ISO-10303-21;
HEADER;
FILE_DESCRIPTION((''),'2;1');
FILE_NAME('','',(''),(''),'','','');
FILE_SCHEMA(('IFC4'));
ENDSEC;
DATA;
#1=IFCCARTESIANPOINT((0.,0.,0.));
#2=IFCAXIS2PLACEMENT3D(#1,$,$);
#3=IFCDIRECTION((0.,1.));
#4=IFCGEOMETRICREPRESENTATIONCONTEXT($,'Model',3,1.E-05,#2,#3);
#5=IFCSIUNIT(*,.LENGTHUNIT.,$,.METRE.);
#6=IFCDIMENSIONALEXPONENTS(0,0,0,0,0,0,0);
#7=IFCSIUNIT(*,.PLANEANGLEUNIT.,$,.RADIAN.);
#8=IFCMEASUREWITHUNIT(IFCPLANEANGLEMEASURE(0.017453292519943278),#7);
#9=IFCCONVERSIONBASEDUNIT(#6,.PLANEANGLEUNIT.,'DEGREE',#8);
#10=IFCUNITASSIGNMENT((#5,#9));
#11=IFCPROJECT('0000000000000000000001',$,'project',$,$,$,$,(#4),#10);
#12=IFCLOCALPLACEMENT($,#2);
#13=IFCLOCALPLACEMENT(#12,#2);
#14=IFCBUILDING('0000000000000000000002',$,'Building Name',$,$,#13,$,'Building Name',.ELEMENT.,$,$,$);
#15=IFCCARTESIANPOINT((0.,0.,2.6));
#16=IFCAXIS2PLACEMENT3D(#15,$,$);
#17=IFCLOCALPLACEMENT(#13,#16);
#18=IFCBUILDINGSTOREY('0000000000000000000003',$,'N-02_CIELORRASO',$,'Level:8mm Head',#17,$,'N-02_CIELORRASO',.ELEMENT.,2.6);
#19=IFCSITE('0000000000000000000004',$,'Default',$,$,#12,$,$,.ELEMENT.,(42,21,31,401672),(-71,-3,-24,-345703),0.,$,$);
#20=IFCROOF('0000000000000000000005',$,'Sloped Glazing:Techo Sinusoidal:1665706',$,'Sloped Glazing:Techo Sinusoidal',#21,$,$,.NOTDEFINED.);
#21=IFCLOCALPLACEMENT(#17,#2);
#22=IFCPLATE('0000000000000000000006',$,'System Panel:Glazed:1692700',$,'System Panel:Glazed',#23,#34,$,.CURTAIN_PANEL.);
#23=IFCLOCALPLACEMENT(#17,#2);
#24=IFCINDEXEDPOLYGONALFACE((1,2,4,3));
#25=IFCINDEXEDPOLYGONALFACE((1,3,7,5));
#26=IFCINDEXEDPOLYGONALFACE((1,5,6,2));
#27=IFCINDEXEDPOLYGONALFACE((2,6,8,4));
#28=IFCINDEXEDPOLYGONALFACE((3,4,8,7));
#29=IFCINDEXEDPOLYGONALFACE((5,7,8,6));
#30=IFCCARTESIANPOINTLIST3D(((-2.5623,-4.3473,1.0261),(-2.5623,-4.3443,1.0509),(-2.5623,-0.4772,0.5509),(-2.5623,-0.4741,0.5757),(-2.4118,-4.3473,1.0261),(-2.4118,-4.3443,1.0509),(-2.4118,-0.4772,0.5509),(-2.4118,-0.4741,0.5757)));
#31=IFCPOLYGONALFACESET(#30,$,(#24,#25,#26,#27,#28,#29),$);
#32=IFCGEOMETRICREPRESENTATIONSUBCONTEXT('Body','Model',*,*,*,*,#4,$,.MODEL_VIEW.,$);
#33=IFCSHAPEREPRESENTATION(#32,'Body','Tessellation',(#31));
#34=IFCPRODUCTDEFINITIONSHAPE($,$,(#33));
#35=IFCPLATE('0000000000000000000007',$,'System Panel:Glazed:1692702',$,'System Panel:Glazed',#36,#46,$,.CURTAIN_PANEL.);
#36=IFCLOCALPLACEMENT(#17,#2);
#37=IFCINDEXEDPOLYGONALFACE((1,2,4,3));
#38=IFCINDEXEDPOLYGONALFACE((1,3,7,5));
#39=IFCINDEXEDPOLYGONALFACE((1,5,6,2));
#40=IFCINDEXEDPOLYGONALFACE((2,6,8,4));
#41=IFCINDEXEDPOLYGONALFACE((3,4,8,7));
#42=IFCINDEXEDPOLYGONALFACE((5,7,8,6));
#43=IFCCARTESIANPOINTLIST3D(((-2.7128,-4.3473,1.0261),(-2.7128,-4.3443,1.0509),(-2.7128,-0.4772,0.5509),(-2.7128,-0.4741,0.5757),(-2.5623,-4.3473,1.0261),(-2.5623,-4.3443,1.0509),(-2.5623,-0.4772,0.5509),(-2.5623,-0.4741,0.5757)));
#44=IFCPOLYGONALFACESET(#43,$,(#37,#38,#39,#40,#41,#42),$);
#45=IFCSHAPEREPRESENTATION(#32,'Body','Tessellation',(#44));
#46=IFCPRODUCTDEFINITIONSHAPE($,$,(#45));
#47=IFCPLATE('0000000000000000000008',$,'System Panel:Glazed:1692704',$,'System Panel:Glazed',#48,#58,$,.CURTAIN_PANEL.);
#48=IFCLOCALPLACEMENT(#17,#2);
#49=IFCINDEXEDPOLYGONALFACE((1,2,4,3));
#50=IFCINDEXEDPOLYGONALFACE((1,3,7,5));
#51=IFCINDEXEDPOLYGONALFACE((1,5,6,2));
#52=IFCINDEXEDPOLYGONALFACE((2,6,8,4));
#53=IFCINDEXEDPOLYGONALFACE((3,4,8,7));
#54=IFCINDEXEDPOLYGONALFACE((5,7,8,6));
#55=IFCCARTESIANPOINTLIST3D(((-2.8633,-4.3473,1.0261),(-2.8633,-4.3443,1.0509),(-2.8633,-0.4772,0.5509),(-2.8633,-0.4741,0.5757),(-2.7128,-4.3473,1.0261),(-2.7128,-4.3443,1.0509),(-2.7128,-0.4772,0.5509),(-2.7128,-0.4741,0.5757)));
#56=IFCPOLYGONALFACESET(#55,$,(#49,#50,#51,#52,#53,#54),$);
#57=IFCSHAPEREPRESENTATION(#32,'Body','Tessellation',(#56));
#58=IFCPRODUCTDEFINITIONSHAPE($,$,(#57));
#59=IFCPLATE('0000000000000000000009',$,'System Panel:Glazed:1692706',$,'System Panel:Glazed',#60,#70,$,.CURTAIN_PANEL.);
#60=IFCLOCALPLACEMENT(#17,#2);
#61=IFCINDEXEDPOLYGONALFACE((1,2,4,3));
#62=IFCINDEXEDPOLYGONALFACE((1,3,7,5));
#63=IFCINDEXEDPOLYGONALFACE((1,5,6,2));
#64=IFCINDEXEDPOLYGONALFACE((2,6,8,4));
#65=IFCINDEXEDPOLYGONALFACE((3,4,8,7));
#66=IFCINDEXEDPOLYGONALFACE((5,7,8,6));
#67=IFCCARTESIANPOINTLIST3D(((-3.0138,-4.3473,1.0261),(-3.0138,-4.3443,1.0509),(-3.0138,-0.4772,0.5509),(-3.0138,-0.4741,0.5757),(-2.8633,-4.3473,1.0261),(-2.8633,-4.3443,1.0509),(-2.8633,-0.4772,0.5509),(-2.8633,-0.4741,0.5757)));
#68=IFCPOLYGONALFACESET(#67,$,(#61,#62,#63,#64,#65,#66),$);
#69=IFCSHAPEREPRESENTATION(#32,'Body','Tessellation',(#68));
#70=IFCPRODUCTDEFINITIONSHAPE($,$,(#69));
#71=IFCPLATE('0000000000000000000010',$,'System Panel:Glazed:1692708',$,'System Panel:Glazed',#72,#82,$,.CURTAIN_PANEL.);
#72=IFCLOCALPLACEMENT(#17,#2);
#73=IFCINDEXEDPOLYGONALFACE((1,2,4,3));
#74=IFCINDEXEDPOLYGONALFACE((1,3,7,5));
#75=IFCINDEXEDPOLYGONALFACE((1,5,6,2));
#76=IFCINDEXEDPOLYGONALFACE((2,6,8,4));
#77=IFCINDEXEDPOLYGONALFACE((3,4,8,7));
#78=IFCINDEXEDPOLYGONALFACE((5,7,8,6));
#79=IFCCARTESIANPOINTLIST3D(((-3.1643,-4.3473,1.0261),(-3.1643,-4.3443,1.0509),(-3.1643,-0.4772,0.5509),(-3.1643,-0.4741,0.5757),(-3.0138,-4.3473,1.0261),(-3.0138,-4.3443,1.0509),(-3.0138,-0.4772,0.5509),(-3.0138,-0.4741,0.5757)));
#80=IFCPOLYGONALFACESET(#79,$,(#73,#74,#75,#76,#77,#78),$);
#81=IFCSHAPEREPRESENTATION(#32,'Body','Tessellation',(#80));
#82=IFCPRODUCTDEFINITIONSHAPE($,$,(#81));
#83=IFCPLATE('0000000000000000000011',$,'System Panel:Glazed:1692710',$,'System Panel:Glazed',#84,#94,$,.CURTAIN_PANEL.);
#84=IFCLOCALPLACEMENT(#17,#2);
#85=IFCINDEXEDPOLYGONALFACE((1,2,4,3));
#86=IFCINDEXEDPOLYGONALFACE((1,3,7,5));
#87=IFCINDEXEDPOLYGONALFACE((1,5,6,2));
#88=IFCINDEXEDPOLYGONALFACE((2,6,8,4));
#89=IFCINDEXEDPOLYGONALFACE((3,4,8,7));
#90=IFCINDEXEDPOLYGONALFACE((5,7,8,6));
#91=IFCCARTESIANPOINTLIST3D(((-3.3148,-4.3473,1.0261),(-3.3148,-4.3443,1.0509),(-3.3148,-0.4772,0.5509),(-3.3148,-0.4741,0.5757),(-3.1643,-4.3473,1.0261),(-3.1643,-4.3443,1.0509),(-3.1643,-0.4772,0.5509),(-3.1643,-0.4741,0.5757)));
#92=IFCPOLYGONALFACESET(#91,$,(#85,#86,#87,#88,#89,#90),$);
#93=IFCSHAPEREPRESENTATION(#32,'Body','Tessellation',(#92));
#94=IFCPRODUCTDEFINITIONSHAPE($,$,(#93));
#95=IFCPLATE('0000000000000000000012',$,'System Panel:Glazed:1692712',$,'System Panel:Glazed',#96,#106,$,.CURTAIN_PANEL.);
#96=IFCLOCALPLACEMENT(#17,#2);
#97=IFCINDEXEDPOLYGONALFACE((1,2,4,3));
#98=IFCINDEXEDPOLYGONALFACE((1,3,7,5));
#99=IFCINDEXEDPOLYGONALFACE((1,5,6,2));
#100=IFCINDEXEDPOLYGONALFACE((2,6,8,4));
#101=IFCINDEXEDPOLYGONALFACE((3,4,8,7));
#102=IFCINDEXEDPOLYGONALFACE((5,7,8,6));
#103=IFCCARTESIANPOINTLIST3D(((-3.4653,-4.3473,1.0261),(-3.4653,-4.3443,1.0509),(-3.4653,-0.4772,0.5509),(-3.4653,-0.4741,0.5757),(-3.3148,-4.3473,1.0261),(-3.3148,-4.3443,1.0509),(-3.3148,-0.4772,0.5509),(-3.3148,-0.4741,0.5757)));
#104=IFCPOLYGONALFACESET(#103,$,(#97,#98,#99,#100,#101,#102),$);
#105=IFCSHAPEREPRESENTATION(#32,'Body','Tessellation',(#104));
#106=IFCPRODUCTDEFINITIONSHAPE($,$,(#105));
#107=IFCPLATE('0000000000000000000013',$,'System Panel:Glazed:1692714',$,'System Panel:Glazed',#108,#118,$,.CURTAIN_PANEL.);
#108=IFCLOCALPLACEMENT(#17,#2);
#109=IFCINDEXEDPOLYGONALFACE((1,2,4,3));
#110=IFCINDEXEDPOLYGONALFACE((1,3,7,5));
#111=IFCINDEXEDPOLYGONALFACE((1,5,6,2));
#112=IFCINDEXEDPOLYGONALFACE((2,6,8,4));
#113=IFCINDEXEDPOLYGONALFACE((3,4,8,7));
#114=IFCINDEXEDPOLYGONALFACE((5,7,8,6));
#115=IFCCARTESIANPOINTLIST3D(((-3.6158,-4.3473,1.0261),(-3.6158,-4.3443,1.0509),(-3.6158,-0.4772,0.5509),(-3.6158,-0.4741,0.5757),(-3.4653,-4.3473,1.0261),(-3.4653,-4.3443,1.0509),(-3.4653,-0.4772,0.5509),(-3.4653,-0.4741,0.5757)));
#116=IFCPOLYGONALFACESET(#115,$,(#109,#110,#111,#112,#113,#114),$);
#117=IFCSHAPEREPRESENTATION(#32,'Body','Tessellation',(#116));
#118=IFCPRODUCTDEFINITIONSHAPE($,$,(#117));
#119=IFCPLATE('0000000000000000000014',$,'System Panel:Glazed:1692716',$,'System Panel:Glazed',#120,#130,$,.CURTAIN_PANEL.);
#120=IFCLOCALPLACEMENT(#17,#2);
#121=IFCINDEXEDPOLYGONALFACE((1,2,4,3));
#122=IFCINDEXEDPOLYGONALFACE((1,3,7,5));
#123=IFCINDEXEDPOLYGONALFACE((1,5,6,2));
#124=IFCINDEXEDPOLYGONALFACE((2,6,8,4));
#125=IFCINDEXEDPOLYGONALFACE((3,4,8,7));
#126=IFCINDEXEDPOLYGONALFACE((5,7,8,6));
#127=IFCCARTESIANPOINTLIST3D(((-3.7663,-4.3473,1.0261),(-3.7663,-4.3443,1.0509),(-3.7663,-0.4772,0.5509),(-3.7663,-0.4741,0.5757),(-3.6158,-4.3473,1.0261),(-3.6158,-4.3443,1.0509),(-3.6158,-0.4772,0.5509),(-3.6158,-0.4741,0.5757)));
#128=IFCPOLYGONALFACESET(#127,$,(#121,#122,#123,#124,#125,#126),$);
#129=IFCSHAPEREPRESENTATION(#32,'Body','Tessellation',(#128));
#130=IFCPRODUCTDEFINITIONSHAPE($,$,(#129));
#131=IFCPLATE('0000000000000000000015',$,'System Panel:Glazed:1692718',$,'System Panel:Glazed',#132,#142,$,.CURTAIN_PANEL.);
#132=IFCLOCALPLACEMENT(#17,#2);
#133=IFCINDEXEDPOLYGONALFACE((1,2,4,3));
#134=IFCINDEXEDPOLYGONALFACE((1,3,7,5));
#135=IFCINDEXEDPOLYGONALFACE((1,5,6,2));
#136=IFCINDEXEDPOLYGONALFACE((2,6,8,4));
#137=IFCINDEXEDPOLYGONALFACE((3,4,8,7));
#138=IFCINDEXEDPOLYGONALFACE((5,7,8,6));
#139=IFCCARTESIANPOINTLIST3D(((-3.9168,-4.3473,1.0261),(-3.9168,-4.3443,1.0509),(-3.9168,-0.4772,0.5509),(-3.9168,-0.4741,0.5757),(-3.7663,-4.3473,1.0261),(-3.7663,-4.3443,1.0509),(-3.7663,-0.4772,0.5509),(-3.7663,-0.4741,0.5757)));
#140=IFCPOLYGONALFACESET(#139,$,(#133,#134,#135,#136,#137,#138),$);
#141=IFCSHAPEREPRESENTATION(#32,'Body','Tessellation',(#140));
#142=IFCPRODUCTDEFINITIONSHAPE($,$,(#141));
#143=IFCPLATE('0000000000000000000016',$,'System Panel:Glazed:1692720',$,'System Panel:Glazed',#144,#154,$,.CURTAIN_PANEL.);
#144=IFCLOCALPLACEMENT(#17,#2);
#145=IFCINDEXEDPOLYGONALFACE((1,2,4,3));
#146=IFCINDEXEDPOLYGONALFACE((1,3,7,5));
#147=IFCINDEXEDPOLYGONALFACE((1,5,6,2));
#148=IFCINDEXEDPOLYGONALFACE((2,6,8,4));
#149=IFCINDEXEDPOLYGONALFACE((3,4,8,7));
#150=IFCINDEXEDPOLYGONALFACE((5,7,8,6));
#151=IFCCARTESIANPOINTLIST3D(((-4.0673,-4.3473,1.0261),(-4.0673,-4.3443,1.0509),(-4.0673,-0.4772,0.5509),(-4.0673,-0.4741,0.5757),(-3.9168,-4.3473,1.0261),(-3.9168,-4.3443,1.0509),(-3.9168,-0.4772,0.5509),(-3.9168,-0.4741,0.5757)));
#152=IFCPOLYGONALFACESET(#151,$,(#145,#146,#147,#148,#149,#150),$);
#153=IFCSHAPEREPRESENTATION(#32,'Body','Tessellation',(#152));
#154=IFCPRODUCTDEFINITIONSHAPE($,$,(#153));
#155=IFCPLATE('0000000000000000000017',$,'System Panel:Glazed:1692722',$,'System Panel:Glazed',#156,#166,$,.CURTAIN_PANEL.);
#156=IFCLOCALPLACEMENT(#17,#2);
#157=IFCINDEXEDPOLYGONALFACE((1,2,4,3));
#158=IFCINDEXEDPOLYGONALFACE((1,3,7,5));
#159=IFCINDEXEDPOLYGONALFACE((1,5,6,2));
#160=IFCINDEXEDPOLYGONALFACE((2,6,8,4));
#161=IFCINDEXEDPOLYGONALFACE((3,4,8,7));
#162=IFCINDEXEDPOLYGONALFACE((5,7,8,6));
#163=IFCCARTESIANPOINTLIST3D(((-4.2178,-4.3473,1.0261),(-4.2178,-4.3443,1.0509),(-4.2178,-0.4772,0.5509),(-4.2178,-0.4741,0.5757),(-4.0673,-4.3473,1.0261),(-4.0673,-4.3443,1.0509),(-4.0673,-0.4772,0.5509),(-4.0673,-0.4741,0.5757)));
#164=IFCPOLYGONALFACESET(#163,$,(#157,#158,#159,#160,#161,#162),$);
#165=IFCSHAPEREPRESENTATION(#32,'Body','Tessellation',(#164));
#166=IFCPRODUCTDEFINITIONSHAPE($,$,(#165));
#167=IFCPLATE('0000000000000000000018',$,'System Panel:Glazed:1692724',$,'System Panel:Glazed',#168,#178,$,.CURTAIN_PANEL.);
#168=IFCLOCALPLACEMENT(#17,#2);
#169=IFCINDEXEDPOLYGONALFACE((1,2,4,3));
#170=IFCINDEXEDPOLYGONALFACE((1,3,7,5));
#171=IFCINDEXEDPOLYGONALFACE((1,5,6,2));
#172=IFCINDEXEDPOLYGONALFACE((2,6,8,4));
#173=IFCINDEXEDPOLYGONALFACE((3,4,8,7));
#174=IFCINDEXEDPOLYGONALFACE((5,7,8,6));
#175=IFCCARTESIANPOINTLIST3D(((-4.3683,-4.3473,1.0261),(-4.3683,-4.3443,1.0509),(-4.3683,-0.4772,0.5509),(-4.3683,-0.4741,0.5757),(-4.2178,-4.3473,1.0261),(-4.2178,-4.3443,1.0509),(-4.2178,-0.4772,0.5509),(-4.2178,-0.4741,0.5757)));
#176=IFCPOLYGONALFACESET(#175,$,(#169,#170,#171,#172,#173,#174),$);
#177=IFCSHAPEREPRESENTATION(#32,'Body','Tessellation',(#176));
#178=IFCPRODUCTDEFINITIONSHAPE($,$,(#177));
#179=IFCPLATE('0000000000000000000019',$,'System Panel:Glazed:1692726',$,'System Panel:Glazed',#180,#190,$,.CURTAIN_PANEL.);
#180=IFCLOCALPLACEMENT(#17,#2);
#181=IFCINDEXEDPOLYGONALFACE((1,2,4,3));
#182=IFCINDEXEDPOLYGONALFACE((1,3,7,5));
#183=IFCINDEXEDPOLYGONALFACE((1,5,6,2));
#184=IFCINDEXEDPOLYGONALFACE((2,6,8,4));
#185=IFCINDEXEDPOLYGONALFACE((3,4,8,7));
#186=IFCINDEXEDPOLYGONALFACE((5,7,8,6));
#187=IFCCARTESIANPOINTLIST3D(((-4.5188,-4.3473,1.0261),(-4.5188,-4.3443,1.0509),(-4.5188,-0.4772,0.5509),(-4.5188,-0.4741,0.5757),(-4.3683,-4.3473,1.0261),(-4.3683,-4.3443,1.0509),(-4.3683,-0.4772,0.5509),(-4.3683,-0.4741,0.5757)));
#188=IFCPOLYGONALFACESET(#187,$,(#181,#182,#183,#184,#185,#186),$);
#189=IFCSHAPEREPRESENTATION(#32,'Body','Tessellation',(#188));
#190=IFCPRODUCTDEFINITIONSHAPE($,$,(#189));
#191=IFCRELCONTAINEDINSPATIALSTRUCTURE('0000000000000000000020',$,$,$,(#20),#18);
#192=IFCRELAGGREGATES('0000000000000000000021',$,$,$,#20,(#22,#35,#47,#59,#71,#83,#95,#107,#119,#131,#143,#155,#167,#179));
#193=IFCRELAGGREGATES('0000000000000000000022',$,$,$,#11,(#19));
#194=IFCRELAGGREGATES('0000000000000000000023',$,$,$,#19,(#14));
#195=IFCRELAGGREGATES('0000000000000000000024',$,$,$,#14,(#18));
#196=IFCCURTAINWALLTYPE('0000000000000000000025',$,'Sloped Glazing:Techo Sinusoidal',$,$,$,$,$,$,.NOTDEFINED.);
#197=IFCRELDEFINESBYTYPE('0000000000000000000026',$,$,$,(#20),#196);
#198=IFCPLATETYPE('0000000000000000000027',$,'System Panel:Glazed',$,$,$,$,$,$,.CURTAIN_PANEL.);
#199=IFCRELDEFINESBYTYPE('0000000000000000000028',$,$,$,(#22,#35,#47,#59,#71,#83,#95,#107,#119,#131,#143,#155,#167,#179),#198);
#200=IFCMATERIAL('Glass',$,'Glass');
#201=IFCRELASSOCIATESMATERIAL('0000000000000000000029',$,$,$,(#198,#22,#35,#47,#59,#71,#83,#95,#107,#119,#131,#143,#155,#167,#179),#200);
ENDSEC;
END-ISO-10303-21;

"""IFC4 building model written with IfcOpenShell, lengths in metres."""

from ifc_helpers import new_model, entity, si_unit, converted_unit, direction, frame, origin, place, context, subcontext, project, spatial, indexed_curve, outline, extrude, source, transform, mapped, material, type_object, type_shapes, element, aggregate, save


model = new_model("IFC4")

# Units and contexts
model_context = context("Model", 3, precision=1e-05, world=origin(), true_north=direction((0.0, 1.0)))
body_context = subcontext(model_context, "Body", "Model", "MODEL_VIEW")
ifc_project = project(units=[si_unit("LENGTHUNIT", "METRE"), converted_unit("PLANEANGLEUNIT", "DEGREE", entity("IfcPlaneAngleMeasure", 0.017453292519943278), si_unit("PLANEANGLEUNIT", "RADIAN"), dimensions=[0, 0, 0, 0, 0, 0, 0])], contexts=[model_context])

# Site, building, storey
site_placement = place(None, origin())
site = spatial("IfcSite", under=ifc_project, at=site_placement, Name="Default", CompositionType="ELEMENT", RefLatitude=(42, 21, 31, 401672), RefLongitude=(-71, -3, -24, -345703), RefElevation=0.0)
building_placement = place(site_placement, origin())
building = spatial("IfcBuilding", under=site, at=building_placement, Name="Building Name", LongName="Building Name", CompositionType="ELEMENT")
storey_placement = place(building_placement, frame((0.0, 0.0, 2.6)))
storey = spatial("IfcBuildingStorey", under=building, at=storey_placement, Name="N-02_CIELORRASO", ObjectType="Level:8mm Head", LongName="N-02_CIELORRASO", CompositionType="ELEMENT", Elevation=2.6)

# Shared definitions
curtain_wall_type = type_object("IfcCurtainWallType", Name="Sloped Glazing:Techo Sinusoidal", PredefinedType="NOTDEFINED")

# Roof, plates
roof_1_placement = place(storey_placement, frame((0.0, 0.0, -2.6)))
roof_1 = element("IfcRoof", 1, at=roof_1_placement, inside=storey, type_object=curtain_wall_type, Name="Sloped Glazing:Techo Sinusoidal:1665706", ObjectType="Sloped Glazing:Techo Sinusoidal", PredefinedType="NOTDEFINED")
ifc_material_1 = material(Name="Glass", Category="Glass")
plate_type_1 = type_object("IfcPlateType", Name="System Panel:Glazed", PredefinedType="CURTAIN_PANEL", material=ifc_material_1)
shared_shape_1 = source(origin(), body_context, "Body", "SweptSolid", [
    extrude(outline(indexed_curve([(-0.0125, -0.0753), (0.0125, -0.0753), (0.0125, 0.0753), (-0.0125, 0.0753), (-0.0125, -0.0753)], self_intersect=False)), frame((0.0, 0.037, 0.0), z_axis=(0.0, 0.0, 1.0), x_axis=(0.0, 1.0, 0.0)), (0.0, 0.0, 1.0), 3.8992),
])
type_shapes(plate_type_1, [shared_shape_1])
plate_1_placement = place(roof_1_placement, frame((-2.487, -0.4711, 3.2), z_axis=(0.0, -0.992546, 0.121869), x_axis=(-1.0, 0.0, 0.0)))
plate_1 = element("IfcPlate", 2, at=plate_1_placement, type_object=plate_type_1, material=ifc_material_1, Name="System Panel:Glazed:1692700", ObjectType="System Panel:Glazed", PredefinedType="CURTAIN_PANEL", context=body_context, shape_type="MappedRepresentation", body=[
    mapped(shared_shape_1, transform((0.0, 0.0, 0.0), scale=1.0)),
])
plate_2_placement = place(roof_1_placement, frame((-2.6375, -0.4711, 3.2), z_axis=(0.0, -0.992546, 0.121869), x_axis=(-1.0, 0.0, 0.0)))
plate_2 = element("IfcPlate", 3, at=plate_2_placement, type_object=plate_type_1, material=ifc_material_1, Name="System Panel:Glazed:1692702", ObjectType="System Panel:Glazed", PredefinedType="CURTAIN_PANEL", context=body_context, shape_type="MappedRepresentation", body=[
    mapped(shared_shape_1, transform((0.0, 0.0, 0.0), scale=1.0)),
])
plate_3_placement = place(roof_1_placement, frame((-2.788, -0.4711, 3.2), z_axis=(0.0, -0.992546, 0.121869), x_axis=(-1.0, 0.0, 0.0)))
plate_3 = element("IfcPlate", 4, at=plate_3_placement, type_object=plate_type_1, material=ifc_material_1, Name="System Panel:Glazed:1692704", ObjectType="System Panel:Glazed", PredefinedType="CURTAIN_PANEL", context=body_context, shape_type="MappedRepresentation", body=[
    mapped(shared_shape_1, transform((0.0, 0.0, 0.0), scale=1.0)),
])
plate_4_placement = place(roof_1_placement, frame((-2.9385, -0.4711, 3.2), z_axis=(0.0, -0.992546, 0.121869), x_axis=(-1.0, 0.0, 0.0)))
plate_4 = element("IfcPlate", 5, at=plate_4_placement, type_object=plate_type_1, material=ifc_material_1, Name="System Panel:Glazed:1692706", ObjectType="System Panel:Glazed", PredefinedType="CURTAIN_PANEL", context=body_context, shape_type="MappedRepresentation", body=[
    mapped(shared_shape_1, transform((0.0, 0.0, 0.0), scale=1.0)),
])
plate_5_placement = place(roof_1_placement, frame((-3.089, -0.4711, 3.2), z_axis=(0.0, -0.992546, 0.121869), x_axis=(-1.0, 0.0, 0.0)))
plate_5 = element("IfcPlate", 6, at=plate_5_placement, type_object=plate_type_1, material=ifc_material_1, Name="System Panel:Glazed:1692708", ObjectType="System Panel:Glazed", PredefinedType="CURTAIN_PANEL", context=body_context, shape_type="MappedRepresentation", body=[
    mapped(shared_shape_1, transform((0.0, 0.0, 0.0), scale=1.0)),
])
plate_6_placement = place(roof_1_placement, frame((-3.2395, -0.4711, 3.2), z_axis=(0.0, -0.992546, 0.121869), x_axis=(-1.0, 0.0, 0.0)))
plate_6 = element("IfcPlate", 7, at=plate_6_placement, type_object=plate_type_1, material=ifc_material_1, Name="System Panel:Glazed:1692710", ObjectType="System Panel:Glazed", PredefinedType="CURTAIN_PANEL", context=body_context, shape_type="MappedRepresentation", body=[
    mapped(shared_shape_1, transform((0.0, 0.0, 0.0), scale=1.0)),
])
plate_7_placement = place(roof_1_placement, frame((-3.39, -0.4711, 3.2), z_axis=(0.0, -0.992546, 0.121869), x_axis=(-1.0, 0.0, 0.0)))
plate_7 = element("IfcPlate", 8, at=plate_7_placement, type_object=plate_type_1, material=ifc_material_1, Name="System Panel:Glazed:1692712", ObjectType="System Panel:Glazed", PredefinedType="CURTAIN_PANEL", context=body_context, shape_type="MappedRepresentation", body=[
    mapped(shared_shape_1, transform((0.0, 0.0, 0.0), scale=1.0)),
])
plate_8_placement = place(roof_1_placement, frame((-3.5405, -0.4711, 3.2), z_axis=(0.0, -0.992546, 0.121869), x_axis=(-1.0, 0.0, 0.0)))
plate_8 = element("IfcPlate", 9, at=plate_8_placement, type_object=plate_type_1, material=ifc_material_1, Name="System Panel:Glazed:1692714", ObjectType="System Panel:Glazed", PredefinedType="CURTAIN_PANEL", context=body_context, shape_type="MappedRepresentation", body=[
    mapped(shared_shape_1, transform((0.0, 0.0, 0.0), scale=1.0)),
])
plate_9_placement = place(roof_1_placement, frame((-3.691, -0.4711, 3.2), z_axis=(0.0, -0.992546, 0.121869), x_axis=(-1.0, 0.0, 0.0)))
plate_9 = element("IfcPlate", 10, at=plate_9_placement, type_object=plate_type_1, material=ifc_material_1, Name="System Panel:Glazed:1692716", ObjectType="System Panel:Glazed", PredefinedType="CURTAIN_PANEL", context=body_context, shape_type="MappedRepresentation", body=[
    mapped(shared_shape_1, transform((0.0, 0.0, 0.0), scale=1.0)),
])
plate_10_placement = place(roof_1_placement, frame((-3.8415, -0.4711, 3.2), z_axis=(0.0, -0.992546, 0.121869), x_axis=(-1.0, 0.0, 0.0)))
plate_10 = element("IfcPlate", 11, at=plate_10_placement, type_object=plate_type_1, material=ifc_material_1, Name="System Panel:Glazed:1692718", ObjectType="System Panel:Glazed", PredefinedType="CURTAIN_PANEL", context=body_context, shape_type="MappedRepresentation", body=[
    mapped(shared_shape_1, transform((0.0, 0.0, 0.0), scale=1.0)),
])
plate_11_placement = place(roof_1_placement, frame((-3.992, -0.4711, 3.2), z_axis=(0.0, -0.992546, 0.121869), x_axis=(-1.0, 0.0, 0.0)))
plate_11 = element("IfcPlate", 12, at=plate_11_placement, type_object=plate_type_1, material=ifc_material_1, Name="System Panel:Glazed:1692720", ObjectType="System Panel:Glazed", PredefinedType="CURTAIN_PANEL", context=body_context, shape_type="MappedRepresentation", body=[
    mapped(shared_shape_1, transform((0.0, 0.0, 0.0), scale=1.0)),
])
plate_12_placement = place(roof_1_placement, frame((-4.1425, -0.4711, 3.2), z_axis=(0.0, -0.992546, 0.121869), x_axis=(-1.0, 0.0, 0.0)))
plate_12 = element("IfcPlate", 13, at=plate_12_placement, type_object=plate_type_1, material=ifc_material_1, Name="System Panel:Glazed:1692722", ObjectType="System Panel:Glazed", PredefinedType="CURTAIN_PANEL", context=body_context, shape_type="MappedRepresentation", body=[
    mapped(shared_shape_1, transform((0.0, 0.0, 0.0), scale=1.0)),
])
plate_13_placement = place(roof_1_placement, frame((-4.293, -0.4711, 3.2), z_axis=(0.0, -0.992546, 0.121869), x_axis=(-1.0, 0.0, 0.0)))
plate_13 = element("IfcPlate", 14, at=plate_13_placement, type_object=plate_type_1, material=ifc_material_1, Name="System Panel:Glazed:1692724", ObjectType="System Panel:Glazed", PredefinedType="CURTAIN_PANEL", context=body_context, shape_type="MappedRepresentation", body=[
    mapped(shared_shape_1, transform((0.0, 0.0, 0.0), scale=1.0)),
])
plate_14_placement = place(roof_1_placement, frame((-4.4435, -0.4711, 3.2), z_axis=(0.0, -0.992546, 0.121869), x_axis=(-1.0, 0.0, 0.0)))
plate_14 = element("IfcPlate", 15, at=plate_14_placement, type_object=plate_type_1, material=ifc_material_1, Name="System Panel:Glazed:1692726", ObjectType="System Panel:Glazed", PredefinedType="CURTAIN_PANEL", context=body_context, shape_type="MappedRepresentation", body=[
    mapped(shared_shape_1, transform((0.0, 0.0, 0.0), scale=1.0)),
])
aggregate(roof_1, [plate_1, plate_2, plate_3, plate_4, plate_5, plate_6, plate_7, plate_8, plate_9, plate_10, plate_11, plate_12, plate_13, plate_14])

save(model, "model.ifc")
